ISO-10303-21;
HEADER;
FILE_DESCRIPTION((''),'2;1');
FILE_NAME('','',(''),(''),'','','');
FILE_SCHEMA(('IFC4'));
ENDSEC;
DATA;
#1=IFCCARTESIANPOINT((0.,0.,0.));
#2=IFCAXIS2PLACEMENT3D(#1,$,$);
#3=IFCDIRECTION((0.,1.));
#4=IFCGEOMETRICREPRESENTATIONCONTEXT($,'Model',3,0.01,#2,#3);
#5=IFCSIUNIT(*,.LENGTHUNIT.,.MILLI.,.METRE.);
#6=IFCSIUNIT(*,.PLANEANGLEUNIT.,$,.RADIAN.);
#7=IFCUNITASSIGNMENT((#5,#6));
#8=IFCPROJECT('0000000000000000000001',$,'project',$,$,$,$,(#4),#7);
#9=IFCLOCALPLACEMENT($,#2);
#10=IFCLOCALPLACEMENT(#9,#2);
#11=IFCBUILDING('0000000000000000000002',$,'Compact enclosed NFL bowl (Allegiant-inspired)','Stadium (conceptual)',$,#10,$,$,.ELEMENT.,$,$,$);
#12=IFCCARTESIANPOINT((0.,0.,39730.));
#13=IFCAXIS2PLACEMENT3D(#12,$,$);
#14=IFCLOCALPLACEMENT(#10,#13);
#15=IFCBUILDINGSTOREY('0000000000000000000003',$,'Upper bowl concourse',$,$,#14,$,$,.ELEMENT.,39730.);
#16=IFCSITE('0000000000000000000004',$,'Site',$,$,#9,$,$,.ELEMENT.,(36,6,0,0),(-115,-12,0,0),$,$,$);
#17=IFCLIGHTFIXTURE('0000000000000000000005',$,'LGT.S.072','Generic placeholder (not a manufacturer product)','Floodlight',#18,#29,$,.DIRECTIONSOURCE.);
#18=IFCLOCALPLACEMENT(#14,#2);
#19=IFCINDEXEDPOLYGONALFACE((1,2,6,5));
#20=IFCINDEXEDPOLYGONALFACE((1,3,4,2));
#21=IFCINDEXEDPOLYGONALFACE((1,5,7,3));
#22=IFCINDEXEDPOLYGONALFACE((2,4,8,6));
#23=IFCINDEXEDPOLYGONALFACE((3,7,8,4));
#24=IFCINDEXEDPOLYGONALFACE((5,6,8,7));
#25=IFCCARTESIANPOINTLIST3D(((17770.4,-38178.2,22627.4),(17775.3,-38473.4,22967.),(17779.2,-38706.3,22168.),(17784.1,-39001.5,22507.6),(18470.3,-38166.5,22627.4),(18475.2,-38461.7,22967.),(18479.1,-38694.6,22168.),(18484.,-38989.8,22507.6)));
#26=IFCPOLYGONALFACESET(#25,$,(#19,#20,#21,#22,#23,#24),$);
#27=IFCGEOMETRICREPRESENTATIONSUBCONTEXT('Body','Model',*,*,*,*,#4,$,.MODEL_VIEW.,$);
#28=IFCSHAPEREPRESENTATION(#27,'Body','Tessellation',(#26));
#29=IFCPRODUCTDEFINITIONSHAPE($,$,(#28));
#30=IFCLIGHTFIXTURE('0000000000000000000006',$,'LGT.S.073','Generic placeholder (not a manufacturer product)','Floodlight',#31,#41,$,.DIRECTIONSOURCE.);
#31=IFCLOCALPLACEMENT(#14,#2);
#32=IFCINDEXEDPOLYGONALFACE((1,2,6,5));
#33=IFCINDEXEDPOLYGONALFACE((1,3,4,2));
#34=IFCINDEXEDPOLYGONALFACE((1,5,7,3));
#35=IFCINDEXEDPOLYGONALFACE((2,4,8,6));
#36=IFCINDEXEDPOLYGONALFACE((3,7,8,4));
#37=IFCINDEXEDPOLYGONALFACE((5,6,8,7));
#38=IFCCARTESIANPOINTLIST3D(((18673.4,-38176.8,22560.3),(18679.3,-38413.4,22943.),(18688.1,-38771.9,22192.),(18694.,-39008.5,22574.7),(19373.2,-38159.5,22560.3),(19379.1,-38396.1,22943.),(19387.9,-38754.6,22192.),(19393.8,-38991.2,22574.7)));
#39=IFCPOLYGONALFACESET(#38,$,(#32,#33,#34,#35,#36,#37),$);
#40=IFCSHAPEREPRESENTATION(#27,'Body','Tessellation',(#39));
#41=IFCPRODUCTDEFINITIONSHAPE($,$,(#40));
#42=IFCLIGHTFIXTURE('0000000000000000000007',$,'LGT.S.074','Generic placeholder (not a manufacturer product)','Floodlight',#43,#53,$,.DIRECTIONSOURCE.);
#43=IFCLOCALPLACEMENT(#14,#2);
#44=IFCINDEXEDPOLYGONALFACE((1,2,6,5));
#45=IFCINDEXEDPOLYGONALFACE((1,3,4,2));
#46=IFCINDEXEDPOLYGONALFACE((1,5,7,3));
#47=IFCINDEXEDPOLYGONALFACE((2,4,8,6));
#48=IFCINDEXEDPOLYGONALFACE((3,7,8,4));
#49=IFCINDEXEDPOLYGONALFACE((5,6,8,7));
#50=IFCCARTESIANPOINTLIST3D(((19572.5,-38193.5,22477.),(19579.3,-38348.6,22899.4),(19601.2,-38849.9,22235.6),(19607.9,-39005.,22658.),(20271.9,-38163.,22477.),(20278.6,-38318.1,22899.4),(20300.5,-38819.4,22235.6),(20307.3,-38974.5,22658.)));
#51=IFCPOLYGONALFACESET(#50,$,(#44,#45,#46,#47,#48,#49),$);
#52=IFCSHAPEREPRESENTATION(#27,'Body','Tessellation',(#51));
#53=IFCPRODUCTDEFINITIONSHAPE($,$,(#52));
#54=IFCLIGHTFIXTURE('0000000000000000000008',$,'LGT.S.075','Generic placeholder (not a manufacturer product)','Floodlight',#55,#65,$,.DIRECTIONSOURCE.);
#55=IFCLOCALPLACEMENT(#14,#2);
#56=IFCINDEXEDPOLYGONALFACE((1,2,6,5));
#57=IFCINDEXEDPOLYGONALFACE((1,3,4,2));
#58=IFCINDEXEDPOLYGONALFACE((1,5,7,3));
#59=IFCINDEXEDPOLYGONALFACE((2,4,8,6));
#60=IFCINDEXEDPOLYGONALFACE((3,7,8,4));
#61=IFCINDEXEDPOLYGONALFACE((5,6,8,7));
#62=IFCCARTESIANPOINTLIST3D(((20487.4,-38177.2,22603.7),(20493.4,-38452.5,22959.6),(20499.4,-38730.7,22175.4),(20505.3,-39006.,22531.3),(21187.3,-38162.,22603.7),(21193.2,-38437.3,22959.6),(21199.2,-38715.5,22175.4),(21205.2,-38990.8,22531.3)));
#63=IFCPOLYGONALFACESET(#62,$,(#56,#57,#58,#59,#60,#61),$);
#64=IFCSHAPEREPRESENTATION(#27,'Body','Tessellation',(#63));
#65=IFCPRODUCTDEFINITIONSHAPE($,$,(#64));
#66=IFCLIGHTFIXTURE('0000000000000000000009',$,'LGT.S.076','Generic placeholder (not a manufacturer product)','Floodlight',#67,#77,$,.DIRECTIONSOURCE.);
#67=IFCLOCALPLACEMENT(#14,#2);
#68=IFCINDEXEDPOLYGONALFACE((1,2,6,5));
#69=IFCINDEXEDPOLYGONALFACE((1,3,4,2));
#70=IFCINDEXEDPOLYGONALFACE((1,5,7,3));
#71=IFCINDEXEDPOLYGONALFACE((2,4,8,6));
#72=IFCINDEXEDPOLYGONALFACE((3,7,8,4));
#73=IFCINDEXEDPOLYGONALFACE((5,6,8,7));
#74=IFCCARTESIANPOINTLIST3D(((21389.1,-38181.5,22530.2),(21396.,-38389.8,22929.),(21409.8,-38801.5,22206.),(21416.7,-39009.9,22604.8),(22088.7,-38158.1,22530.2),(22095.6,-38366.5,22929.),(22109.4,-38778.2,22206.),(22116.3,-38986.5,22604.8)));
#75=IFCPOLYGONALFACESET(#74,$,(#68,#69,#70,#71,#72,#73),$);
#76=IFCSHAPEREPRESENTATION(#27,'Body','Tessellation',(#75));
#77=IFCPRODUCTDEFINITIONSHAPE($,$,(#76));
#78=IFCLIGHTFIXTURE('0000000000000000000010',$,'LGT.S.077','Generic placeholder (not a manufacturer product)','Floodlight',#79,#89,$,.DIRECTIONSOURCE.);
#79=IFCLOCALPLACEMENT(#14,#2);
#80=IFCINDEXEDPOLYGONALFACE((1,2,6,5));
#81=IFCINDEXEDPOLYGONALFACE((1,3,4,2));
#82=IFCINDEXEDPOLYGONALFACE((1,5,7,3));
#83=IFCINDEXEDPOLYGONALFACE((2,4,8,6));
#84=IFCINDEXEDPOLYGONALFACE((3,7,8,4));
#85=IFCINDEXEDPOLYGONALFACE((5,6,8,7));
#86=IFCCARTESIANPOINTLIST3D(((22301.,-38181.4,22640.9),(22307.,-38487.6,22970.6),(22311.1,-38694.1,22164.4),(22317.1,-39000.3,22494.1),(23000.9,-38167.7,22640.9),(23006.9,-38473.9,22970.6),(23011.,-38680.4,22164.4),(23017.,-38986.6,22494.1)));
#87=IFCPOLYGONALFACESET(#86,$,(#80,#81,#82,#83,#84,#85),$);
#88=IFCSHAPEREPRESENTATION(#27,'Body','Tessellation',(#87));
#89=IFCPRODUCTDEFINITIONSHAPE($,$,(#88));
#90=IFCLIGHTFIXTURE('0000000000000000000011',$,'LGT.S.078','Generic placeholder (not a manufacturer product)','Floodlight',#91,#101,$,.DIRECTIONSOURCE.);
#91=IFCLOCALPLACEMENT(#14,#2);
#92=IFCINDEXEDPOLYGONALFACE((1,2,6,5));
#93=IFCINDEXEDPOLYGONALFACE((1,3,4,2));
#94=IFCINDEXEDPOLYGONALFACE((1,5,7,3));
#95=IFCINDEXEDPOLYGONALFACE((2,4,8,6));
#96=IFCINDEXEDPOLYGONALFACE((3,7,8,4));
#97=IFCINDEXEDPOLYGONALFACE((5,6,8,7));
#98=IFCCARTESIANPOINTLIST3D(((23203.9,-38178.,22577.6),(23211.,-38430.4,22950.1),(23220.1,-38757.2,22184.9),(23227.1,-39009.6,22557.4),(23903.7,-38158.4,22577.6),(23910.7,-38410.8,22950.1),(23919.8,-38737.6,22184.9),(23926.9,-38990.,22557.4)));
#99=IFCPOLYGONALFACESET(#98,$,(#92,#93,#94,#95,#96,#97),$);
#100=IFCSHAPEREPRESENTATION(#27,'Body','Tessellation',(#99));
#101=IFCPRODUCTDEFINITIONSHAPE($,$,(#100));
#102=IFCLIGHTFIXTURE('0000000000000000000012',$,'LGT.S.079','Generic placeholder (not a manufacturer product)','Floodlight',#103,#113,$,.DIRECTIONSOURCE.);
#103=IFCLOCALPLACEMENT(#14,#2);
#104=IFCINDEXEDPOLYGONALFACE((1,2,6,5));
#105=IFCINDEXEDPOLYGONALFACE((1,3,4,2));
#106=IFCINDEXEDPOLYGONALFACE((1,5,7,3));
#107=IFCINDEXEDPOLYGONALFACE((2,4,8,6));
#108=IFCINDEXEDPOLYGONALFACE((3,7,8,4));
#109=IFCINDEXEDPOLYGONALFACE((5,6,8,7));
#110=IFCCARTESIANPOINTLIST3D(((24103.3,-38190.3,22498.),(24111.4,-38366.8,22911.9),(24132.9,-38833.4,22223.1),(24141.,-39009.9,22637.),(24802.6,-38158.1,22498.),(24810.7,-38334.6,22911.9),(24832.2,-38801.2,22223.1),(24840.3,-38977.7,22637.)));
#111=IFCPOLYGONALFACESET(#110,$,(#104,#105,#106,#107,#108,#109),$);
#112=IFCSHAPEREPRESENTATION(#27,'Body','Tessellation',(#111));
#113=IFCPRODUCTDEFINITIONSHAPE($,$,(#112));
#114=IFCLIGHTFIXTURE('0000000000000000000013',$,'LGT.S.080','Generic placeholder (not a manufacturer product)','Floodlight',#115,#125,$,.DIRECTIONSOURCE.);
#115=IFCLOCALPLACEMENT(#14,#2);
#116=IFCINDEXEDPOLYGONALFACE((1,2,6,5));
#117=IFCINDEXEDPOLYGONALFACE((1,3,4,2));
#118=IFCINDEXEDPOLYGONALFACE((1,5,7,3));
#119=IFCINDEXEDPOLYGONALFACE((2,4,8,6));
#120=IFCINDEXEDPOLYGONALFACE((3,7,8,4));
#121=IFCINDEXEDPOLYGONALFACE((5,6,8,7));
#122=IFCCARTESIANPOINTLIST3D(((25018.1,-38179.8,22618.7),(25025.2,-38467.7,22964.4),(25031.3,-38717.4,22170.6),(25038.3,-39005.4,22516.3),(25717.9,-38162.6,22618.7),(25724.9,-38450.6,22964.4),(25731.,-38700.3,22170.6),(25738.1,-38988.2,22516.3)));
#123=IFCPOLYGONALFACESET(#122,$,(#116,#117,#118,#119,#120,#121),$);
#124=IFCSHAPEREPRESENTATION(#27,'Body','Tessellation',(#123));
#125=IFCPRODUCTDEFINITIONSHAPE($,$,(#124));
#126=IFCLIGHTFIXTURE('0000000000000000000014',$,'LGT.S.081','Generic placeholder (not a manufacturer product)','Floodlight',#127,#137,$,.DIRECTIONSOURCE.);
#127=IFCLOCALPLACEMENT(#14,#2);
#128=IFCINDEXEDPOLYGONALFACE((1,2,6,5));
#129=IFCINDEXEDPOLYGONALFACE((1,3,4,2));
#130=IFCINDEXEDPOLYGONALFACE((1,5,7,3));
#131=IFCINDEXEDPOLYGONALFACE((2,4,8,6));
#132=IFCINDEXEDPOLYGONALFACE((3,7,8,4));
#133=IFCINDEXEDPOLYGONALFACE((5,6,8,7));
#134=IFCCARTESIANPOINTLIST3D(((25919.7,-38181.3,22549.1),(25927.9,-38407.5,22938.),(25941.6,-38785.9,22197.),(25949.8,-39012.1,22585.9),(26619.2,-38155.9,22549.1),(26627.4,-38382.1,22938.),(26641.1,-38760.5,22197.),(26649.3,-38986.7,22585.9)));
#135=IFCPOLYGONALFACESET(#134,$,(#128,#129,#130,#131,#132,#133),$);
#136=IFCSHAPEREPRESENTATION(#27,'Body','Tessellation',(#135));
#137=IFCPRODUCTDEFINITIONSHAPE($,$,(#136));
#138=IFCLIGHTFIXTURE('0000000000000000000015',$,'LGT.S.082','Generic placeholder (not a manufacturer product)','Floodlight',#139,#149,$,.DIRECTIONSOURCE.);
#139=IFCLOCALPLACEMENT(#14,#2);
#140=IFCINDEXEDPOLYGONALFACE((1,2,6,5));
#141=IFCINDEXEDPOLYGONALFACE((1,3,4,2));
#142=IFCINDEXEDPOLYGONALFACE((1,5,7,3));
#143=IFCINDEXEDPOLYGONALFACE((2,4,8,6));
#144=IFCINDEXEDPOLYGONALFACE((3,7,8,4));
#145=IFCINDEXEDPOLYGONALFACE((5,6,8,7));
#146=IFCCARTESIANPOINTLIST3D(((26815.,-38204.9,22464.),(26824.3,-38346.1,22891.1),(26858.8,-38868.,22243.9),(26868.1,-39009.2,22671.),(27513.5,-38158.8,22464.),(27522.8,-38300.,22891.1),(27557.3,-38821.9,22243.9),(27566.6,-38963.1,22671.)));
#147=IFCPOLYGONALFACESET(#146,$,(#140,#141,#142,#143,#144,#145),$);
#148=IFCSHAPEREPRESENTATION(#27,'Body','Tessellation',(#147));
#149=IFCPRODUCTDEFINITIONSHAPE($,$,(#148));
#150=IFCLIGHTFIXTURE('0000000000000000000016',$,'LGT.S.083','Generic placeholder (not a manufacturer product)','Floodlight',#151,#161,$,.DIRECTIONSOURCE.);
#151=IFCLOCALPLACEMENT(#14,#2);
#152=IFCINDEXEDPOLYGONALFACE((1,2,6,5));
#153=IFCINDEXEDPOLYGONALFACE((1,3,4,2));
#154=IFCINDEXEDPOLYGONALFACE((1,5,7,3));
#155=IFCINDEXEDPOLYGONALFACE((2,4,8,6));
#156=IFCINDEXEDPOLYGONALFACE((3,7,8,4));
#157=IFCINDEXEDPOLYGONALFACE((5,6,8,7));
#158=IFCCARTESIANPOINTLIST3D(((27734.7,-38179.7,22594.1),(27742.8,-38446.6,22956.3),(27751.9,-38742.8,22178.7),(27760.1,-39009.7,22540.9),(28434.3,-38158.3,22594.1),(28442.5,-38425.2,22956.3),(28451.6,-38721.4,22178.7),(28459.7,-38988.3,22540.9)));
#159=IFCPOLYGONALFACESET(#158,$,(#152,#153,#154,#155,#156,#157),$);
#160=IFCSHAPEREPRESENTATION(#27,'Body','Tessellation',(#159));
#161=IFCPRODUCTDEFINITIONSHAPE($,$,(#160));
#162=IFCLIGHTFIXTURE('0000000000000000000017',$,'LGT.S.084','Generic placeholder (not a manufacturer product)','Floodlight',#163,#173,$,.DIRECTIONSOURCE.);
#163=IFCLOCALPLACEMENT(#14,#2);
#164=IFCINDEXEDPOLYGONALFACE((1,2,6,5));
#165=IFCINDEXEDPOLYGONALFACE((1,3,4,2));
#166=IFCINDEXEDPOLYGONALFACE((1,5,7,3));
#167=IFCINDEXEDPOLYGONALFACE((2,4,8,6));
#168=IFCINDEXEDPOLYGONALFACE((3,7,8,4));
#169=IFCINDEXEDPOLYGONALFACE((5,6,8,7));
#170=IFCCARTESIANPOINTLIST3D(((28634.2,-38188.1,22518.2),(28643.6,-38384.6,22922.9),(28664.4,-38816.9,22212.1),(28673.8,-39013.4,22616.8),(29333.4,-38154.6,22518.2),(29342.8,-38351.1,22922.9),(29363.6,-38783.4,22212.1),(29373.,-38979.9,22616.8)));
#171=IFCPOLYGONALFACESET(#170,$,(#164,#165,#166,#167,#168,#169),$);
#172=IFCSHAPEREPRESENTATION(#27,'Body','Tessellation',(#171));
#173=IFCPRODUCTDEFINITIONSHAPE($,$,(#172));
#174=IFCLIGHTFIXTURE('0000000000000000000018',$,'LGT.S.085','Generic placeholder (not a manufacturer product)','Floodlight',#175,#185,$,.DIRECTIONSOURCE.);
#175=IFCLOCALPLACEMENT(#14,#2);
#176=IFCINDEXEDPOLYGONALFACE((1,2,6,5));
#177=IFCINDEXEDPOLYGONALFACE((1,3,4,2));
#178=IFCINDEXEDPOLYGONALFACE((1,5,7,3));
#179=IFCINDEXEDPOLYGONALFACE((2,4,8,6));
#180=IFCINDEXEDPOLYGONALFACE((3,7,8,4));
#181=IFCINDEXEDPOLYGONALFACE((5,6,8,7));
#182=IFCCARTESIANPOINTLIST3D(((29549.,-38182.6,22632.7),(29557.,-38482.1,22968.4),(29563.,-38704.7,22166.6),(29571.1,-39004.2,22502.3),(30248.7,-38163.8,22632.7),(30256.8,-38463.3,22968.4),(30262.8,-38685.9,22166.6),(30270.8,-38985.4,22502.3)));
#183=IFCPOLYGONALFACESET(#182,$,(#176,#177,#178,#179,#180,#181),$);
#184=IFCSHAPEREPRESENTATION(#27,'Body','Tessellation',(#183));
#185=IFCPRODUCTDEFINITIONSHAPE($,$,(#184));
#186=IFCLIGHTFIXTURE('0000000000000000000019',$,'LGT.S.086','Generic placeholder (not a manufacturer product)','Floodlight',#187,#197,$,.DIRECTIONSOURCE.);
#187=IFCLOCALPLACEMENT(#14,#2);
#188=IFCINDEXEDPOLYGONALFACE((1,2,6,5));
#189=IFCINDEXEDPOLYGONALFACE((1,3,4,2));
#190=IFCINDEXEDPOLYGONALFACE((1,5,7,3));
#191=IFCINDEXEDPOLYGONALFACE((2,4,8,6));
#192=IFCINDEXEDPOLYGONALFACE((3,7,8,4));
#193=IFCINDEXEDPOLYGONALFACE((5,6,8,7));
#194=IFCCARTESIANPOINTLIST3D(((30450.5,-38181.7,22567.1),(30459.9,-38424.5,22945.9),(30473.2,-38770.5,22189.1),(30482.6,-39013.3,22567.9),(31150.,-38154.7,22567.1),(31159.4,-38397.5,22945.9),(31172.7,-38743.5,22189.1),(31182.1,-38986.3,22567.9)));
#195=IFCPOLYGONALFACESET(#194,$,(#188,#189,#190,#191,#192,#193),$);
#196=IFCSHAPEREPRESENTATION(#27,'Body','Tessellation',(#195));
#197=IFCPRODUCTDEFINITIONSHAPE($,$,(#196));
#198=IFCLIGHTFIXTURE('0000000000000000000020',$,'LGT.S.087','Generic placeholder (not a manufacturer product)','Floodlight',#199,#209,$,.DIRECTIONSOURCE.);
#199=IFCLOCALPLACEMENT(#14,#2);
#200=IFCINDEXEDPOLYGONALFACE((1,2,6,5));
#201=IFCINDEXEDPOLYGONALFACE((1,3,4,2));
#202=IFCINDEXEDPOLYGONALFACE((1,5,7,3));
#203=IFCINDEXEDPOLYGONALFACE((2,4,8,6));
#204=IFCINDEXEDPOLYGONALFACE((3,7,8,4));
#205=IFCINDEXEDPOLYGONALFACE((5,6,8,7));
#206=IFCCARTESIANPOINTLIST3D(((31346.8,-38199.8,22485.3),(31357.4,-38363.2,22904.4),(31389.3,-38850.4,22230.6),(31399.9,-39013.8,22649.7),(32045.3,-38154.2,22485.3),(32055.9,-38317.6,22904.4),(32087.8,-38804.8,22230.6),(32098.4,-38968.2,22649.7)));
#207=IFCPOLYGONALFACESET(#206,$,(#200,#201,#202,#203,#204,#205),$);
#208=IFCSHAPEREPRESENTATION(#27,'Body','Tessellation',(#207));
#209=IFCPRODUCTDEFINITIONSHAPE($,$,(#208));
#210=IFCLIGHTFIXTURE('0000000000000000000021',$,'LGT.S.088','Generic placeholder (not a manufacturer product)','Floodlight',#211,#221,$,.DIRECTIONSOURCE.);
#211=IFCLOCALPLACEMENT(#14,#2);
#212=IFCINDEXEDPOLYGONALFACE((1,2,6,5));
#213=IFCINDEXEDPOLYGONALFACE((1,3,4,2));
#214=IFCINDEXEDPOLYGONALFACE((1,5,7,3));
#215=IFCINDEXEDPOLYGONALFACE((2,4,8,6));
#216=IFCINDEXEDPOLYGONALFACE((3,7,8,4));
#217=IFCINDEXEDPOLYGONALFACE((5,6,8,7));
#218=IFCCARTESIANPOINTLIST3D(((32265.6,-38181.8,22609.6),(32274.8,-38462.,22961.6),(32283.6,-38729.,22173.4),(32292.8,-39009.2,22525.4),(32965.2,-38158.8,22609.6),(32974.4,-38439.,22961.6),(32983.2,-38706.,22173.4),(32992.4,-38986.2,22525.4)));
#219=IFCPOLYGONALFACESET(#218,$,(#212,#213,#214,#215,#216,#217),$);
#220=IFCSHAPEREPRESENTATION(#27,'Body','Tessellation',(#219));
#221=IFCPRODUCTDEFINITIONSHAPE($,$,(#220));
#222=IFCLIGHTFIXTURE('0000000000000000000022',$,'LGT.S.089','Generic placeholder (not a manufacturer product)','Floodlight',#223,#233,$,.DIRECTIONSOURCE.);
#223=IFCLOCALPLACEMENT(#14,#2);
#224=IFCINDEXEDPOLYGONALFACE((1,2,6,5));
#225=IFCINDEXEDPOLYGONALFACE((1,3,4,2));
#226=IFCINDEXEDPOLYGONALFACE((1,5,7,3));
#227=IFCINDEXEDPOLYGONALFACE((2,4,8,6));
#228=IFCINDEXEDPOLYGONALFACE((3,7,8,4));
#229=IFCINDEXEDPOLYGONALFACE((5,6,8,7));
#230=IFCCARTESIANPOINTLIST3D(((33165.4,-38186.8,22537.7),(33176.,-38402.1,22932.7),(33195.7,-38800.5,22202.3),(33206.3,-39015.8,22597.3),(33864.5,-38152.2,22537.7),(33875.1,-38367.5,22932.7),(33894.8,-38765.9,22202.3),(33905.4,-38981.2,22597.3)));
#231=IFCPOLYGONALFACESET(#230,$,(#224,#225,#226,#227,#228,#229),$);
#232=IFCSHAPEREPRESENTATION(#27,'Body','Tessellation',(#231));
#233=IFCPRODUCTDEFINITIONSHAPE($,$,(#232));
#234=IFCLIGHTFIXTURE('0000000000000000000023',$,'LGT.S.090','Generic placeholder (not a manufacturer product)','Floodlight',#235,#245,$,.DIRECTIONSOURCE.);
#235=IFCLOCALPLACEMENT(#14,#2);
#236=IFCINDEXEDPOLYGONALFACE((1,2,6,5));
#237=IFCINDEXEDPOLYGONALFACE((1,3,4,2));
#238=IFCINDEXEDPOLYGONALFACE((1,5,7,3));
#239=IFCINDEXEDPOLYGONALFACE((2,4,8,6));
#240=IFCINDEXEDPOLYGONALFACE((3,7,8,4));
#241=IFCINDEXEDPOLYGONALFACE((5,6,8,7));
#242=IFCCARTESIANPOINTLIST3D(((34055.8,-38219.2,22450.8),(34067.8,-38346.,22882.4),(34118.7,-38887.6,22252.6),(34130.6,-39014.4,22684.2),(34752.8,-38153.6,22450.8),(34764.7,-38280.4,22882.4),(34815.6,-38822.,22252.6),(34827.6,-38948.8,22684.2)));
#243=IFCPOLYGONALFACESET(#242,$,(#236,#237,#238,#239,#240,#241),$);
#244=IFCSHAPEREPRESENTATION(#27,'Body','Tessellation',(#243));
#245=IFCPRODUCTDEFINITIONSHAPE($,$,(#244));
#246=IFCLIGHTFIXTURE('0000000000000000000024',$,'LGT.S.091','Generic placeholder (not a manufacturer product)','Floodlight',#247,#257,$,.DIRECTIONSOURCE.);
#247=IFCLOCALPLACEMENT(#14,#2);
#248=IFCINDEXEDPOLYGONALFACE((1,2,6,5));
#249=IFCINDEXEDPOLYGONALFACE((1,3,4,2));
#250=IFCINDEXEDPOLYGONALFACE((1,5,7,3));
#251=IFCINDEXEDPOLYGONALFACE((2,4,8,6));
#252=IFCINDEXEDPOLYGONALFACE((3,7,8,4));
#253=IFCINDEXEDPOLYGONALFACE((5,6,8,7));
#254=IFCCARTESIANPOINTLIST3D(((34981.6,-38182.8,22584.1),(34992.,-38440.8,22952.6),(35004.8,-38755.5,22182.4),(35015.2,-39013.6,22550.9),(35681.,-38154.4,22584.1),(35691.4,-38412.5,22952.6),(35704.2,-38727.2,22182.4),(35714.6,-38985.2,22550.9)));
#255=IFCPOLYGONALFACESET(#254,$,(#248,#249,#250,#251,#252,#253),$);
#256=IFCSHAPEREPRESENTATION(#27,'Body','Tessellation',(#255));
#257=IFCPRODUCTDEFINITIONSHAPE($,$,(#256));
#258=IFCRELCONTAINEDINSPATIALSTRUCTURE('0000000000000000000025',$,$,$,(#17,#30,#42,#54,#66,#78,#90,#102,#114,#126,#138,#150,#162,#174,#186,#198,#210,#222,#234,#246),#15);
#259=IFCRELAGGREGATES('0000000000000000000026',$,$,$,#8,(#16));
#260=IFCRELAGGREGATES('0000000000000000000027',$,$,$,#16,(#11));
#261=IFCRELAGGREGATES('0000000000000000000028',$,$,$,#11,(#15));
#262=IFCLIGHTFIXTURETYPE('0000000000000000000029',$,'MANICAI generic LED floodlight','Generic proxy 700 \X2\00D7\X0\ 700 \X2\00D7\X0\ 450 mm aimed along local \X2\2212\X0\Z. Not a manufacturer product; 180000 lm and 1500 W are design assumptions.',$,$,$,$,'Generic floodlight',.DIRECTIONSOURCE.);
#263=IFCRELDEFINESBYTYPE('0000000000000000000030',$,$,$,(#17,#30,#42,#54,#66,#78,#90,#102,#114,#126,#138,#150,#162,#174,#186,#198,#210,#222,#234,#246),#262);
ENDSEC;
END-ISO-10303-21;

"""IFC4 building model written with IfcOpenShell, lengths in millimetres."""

from ifc_helpers import new_model, si_unit, direction, frame, origin, place, context, subcontext, project, spatial, rectangle, extrude, source, transform, mapped, type_object, type_shapes, element, save


model = new_model("IFC4")

# Units and contexts
model_context = context("Model", 3, precision=0.01, world=origin(), true_north=direction((0.0, 1.0)))
body_context = subcontext(model_context, "Body", "Model", "MODEL_VIEW")
ifc_project = project(units=[si_unit("LENGTHUNIT", "METRE", prefix="MILLI"), si_unit("PLANEANGLEUNIT", "RADIAN")], contexts=[model_context])

# Site, building, storey
site_placement = place(None, origin())
site = spatial("IfcSite", under=ifc_project, at=site_placement, Name="Site", CompositionType="ELEMENT", RefLatitude=(36, 6, 0, 0), RefLongitude=(-115, -12, 0, 0))
building_placement = place(site_placement, origin())
building = spatial("IfcBuilding", under=site, at=building_placement, Name="Compact enclosed NFL bowl (Allegiant-inspired)", Description="Stadium (conceptual)", CompositionType="ELEMENT")
storey_placement = place(building_placement, frame((0.0, 0.0, 39730.0)))
storey = spatial("IfcBuildingStorey", under=building, at=storey_placement, Name="Upper bowl concourse", CompositionType="ELEMENT", Elevation=39730.0)

# Light fixtures
light_fixture_type = type_object("IfcLightFixtureType", Name="MANICAI generic LED floodlight", Description="Generic proxy 700 × 700 × 450 mm aimed along local −Z. Not a manufacturer product; 180000 lm and 1500 W are design assumptions.", ElementType="Generic floodlight", PredefinedType="DIRECTIONSOURCE")
shared_shape = source(origin(), body_context, "Body", "SweptSolid", [
    extrude(rectangle(XDim=700.0, YDim=700.0), frame((0.0, 0.0, -225.0)), (0.0, 0.0, 1.0), 450.0),
])
type_shapes(light_fixture_type, [shared_shape])
for number, where, z_axis, x_axis, name in (
    (1, (18127.2, -38584.0, 22567.5), (0.010978, -0.656111, 0.754584), (0.99986, 0.01673, 0.0), "LGT.S.072"),
    (2, (19033.6, -38584.0, 22567.5), (0.012992, -0.525869, 0.850466), (0.999695, 0.024698, 0.0), "LGT.S.073"),
    (3, (19939.9, -38584.0, 22567.5), (0.015022, -0.344623, 0.938621), (0.999051, 0.043547, 0.0), "LGT.S.074"),
    (4, (20846.3, -38584.0, 22567.5), (0.013233, -0.611807, 0.790896), (0.999766, 0.021624, 0.0), "LGT.S.075"),
    (5, (21752.7, -38584.0, 22567.5), (0.015473, -0.462965, 0.886242), (0.999442, 0.033402, 0.0), "LGT.S.076"),
    (6, (22659.0, -38584.0, 22567.5), (0.013324, -0.680478, 0.732647), (0.999808, 0.019577, 0.0), "LGT.S.077"),
    (7, (23565.4, -38584.0, 22567.5), (0.015656, -0.560895, 0.827739), (0.999611, 0.027901, 0.0), "LGT.S.078"),
    (8, (24471.8, -38584.0, 22567.5), (0.018064, -0.392208, 0.919699), (0.998941, 0.046008, 0.0), "LGT.S.079"),
    (9, (25378.1, -38584.0, 22567.5), (0.015649, -0.639889, 0.768308), (0.999701, 0.024449, 0.0), "LGT.S.080"),
    (10, (26284.5, -38584.0, 22567.5), (0.018232, -0.502724, 0.864255), (0.999343, 0.036243, 0.0), "LGT.S.081"),
    (11, (27190.8, -38584.0, 22567.5), (0.020716, -0.31375, 0.94928), (0.997827, 0.065885, 0.0), "LGT.S.082"),
    (12, (28097.2, -38584.0, 22567.5), (0.018151, -0.59314, 0.804895), (0.999532, 0.030587, 0.0), "LGT.S.083"),
    (13, (29003.6, -38584.0, 22567.5), (0.020934, -0.436831, 0.8993), (0.998854, 0.047868, 0.0), "LGT.S.084"),
    (14, (29909.9, -38584.0, 22567.5), (0.01791, -0.665615, 0.746081), (0.999638, 0.026898, 0.0), "LGT.S.085"),
    (15, (30816.3, -38584.0, 22567.5), (0.020818, -0.539521, 0.841715), (0.999256, 0.038558, 0.0), "LGT.S.086"),
    (16, (31722.6, -38584.0, 22567.5), (0.023715, -0.363087, 0.931453), (0.997874, 0.065177, 0.0), "LGT.S.087"),
    (17, (32629.0, -38584.0, 22567.5), (0.020483, -0.622755, 0.782149), (0.99946, 0.032873, 0.0), "LGT.S.088"),
    (18, (33535.4, -38584.0, 22567.5), (0.023627, -0.478437, 0.877804), (0.998783, 0.049323, 0.0), "LGT.S.089"),
    (19, (34441.7, -38584.0, 22567.5), (0.026512, -0.281848, 0.959093), (0.995605, 0.093652, 0.0), "LGT.S.090"),
    (20, (35348.1, -38584.0, 22567.5), (0.023233, -0.573457, 0.818906), (0.99918, 0.04048, 0.0), "LGT.S.091"),
):
    element("IfcLightFixture", number, at=place(storey_placement, frame(where, z_axis=z_axis, x_axis=x_axis)), inside=storey, type_object=light_fixture_type, Name=name, Description="Generic placeholder (not a manufacturer product)", ObjectType="Floodlight", PredefinedType="DIRECTIONSOURCE", context=body_context, shape_type="MappedRepresentation", body=[
        mapped(shared_shape, transform((0.0, 0.0, 0.0))),
    ])

save(model, "model.ifc")
